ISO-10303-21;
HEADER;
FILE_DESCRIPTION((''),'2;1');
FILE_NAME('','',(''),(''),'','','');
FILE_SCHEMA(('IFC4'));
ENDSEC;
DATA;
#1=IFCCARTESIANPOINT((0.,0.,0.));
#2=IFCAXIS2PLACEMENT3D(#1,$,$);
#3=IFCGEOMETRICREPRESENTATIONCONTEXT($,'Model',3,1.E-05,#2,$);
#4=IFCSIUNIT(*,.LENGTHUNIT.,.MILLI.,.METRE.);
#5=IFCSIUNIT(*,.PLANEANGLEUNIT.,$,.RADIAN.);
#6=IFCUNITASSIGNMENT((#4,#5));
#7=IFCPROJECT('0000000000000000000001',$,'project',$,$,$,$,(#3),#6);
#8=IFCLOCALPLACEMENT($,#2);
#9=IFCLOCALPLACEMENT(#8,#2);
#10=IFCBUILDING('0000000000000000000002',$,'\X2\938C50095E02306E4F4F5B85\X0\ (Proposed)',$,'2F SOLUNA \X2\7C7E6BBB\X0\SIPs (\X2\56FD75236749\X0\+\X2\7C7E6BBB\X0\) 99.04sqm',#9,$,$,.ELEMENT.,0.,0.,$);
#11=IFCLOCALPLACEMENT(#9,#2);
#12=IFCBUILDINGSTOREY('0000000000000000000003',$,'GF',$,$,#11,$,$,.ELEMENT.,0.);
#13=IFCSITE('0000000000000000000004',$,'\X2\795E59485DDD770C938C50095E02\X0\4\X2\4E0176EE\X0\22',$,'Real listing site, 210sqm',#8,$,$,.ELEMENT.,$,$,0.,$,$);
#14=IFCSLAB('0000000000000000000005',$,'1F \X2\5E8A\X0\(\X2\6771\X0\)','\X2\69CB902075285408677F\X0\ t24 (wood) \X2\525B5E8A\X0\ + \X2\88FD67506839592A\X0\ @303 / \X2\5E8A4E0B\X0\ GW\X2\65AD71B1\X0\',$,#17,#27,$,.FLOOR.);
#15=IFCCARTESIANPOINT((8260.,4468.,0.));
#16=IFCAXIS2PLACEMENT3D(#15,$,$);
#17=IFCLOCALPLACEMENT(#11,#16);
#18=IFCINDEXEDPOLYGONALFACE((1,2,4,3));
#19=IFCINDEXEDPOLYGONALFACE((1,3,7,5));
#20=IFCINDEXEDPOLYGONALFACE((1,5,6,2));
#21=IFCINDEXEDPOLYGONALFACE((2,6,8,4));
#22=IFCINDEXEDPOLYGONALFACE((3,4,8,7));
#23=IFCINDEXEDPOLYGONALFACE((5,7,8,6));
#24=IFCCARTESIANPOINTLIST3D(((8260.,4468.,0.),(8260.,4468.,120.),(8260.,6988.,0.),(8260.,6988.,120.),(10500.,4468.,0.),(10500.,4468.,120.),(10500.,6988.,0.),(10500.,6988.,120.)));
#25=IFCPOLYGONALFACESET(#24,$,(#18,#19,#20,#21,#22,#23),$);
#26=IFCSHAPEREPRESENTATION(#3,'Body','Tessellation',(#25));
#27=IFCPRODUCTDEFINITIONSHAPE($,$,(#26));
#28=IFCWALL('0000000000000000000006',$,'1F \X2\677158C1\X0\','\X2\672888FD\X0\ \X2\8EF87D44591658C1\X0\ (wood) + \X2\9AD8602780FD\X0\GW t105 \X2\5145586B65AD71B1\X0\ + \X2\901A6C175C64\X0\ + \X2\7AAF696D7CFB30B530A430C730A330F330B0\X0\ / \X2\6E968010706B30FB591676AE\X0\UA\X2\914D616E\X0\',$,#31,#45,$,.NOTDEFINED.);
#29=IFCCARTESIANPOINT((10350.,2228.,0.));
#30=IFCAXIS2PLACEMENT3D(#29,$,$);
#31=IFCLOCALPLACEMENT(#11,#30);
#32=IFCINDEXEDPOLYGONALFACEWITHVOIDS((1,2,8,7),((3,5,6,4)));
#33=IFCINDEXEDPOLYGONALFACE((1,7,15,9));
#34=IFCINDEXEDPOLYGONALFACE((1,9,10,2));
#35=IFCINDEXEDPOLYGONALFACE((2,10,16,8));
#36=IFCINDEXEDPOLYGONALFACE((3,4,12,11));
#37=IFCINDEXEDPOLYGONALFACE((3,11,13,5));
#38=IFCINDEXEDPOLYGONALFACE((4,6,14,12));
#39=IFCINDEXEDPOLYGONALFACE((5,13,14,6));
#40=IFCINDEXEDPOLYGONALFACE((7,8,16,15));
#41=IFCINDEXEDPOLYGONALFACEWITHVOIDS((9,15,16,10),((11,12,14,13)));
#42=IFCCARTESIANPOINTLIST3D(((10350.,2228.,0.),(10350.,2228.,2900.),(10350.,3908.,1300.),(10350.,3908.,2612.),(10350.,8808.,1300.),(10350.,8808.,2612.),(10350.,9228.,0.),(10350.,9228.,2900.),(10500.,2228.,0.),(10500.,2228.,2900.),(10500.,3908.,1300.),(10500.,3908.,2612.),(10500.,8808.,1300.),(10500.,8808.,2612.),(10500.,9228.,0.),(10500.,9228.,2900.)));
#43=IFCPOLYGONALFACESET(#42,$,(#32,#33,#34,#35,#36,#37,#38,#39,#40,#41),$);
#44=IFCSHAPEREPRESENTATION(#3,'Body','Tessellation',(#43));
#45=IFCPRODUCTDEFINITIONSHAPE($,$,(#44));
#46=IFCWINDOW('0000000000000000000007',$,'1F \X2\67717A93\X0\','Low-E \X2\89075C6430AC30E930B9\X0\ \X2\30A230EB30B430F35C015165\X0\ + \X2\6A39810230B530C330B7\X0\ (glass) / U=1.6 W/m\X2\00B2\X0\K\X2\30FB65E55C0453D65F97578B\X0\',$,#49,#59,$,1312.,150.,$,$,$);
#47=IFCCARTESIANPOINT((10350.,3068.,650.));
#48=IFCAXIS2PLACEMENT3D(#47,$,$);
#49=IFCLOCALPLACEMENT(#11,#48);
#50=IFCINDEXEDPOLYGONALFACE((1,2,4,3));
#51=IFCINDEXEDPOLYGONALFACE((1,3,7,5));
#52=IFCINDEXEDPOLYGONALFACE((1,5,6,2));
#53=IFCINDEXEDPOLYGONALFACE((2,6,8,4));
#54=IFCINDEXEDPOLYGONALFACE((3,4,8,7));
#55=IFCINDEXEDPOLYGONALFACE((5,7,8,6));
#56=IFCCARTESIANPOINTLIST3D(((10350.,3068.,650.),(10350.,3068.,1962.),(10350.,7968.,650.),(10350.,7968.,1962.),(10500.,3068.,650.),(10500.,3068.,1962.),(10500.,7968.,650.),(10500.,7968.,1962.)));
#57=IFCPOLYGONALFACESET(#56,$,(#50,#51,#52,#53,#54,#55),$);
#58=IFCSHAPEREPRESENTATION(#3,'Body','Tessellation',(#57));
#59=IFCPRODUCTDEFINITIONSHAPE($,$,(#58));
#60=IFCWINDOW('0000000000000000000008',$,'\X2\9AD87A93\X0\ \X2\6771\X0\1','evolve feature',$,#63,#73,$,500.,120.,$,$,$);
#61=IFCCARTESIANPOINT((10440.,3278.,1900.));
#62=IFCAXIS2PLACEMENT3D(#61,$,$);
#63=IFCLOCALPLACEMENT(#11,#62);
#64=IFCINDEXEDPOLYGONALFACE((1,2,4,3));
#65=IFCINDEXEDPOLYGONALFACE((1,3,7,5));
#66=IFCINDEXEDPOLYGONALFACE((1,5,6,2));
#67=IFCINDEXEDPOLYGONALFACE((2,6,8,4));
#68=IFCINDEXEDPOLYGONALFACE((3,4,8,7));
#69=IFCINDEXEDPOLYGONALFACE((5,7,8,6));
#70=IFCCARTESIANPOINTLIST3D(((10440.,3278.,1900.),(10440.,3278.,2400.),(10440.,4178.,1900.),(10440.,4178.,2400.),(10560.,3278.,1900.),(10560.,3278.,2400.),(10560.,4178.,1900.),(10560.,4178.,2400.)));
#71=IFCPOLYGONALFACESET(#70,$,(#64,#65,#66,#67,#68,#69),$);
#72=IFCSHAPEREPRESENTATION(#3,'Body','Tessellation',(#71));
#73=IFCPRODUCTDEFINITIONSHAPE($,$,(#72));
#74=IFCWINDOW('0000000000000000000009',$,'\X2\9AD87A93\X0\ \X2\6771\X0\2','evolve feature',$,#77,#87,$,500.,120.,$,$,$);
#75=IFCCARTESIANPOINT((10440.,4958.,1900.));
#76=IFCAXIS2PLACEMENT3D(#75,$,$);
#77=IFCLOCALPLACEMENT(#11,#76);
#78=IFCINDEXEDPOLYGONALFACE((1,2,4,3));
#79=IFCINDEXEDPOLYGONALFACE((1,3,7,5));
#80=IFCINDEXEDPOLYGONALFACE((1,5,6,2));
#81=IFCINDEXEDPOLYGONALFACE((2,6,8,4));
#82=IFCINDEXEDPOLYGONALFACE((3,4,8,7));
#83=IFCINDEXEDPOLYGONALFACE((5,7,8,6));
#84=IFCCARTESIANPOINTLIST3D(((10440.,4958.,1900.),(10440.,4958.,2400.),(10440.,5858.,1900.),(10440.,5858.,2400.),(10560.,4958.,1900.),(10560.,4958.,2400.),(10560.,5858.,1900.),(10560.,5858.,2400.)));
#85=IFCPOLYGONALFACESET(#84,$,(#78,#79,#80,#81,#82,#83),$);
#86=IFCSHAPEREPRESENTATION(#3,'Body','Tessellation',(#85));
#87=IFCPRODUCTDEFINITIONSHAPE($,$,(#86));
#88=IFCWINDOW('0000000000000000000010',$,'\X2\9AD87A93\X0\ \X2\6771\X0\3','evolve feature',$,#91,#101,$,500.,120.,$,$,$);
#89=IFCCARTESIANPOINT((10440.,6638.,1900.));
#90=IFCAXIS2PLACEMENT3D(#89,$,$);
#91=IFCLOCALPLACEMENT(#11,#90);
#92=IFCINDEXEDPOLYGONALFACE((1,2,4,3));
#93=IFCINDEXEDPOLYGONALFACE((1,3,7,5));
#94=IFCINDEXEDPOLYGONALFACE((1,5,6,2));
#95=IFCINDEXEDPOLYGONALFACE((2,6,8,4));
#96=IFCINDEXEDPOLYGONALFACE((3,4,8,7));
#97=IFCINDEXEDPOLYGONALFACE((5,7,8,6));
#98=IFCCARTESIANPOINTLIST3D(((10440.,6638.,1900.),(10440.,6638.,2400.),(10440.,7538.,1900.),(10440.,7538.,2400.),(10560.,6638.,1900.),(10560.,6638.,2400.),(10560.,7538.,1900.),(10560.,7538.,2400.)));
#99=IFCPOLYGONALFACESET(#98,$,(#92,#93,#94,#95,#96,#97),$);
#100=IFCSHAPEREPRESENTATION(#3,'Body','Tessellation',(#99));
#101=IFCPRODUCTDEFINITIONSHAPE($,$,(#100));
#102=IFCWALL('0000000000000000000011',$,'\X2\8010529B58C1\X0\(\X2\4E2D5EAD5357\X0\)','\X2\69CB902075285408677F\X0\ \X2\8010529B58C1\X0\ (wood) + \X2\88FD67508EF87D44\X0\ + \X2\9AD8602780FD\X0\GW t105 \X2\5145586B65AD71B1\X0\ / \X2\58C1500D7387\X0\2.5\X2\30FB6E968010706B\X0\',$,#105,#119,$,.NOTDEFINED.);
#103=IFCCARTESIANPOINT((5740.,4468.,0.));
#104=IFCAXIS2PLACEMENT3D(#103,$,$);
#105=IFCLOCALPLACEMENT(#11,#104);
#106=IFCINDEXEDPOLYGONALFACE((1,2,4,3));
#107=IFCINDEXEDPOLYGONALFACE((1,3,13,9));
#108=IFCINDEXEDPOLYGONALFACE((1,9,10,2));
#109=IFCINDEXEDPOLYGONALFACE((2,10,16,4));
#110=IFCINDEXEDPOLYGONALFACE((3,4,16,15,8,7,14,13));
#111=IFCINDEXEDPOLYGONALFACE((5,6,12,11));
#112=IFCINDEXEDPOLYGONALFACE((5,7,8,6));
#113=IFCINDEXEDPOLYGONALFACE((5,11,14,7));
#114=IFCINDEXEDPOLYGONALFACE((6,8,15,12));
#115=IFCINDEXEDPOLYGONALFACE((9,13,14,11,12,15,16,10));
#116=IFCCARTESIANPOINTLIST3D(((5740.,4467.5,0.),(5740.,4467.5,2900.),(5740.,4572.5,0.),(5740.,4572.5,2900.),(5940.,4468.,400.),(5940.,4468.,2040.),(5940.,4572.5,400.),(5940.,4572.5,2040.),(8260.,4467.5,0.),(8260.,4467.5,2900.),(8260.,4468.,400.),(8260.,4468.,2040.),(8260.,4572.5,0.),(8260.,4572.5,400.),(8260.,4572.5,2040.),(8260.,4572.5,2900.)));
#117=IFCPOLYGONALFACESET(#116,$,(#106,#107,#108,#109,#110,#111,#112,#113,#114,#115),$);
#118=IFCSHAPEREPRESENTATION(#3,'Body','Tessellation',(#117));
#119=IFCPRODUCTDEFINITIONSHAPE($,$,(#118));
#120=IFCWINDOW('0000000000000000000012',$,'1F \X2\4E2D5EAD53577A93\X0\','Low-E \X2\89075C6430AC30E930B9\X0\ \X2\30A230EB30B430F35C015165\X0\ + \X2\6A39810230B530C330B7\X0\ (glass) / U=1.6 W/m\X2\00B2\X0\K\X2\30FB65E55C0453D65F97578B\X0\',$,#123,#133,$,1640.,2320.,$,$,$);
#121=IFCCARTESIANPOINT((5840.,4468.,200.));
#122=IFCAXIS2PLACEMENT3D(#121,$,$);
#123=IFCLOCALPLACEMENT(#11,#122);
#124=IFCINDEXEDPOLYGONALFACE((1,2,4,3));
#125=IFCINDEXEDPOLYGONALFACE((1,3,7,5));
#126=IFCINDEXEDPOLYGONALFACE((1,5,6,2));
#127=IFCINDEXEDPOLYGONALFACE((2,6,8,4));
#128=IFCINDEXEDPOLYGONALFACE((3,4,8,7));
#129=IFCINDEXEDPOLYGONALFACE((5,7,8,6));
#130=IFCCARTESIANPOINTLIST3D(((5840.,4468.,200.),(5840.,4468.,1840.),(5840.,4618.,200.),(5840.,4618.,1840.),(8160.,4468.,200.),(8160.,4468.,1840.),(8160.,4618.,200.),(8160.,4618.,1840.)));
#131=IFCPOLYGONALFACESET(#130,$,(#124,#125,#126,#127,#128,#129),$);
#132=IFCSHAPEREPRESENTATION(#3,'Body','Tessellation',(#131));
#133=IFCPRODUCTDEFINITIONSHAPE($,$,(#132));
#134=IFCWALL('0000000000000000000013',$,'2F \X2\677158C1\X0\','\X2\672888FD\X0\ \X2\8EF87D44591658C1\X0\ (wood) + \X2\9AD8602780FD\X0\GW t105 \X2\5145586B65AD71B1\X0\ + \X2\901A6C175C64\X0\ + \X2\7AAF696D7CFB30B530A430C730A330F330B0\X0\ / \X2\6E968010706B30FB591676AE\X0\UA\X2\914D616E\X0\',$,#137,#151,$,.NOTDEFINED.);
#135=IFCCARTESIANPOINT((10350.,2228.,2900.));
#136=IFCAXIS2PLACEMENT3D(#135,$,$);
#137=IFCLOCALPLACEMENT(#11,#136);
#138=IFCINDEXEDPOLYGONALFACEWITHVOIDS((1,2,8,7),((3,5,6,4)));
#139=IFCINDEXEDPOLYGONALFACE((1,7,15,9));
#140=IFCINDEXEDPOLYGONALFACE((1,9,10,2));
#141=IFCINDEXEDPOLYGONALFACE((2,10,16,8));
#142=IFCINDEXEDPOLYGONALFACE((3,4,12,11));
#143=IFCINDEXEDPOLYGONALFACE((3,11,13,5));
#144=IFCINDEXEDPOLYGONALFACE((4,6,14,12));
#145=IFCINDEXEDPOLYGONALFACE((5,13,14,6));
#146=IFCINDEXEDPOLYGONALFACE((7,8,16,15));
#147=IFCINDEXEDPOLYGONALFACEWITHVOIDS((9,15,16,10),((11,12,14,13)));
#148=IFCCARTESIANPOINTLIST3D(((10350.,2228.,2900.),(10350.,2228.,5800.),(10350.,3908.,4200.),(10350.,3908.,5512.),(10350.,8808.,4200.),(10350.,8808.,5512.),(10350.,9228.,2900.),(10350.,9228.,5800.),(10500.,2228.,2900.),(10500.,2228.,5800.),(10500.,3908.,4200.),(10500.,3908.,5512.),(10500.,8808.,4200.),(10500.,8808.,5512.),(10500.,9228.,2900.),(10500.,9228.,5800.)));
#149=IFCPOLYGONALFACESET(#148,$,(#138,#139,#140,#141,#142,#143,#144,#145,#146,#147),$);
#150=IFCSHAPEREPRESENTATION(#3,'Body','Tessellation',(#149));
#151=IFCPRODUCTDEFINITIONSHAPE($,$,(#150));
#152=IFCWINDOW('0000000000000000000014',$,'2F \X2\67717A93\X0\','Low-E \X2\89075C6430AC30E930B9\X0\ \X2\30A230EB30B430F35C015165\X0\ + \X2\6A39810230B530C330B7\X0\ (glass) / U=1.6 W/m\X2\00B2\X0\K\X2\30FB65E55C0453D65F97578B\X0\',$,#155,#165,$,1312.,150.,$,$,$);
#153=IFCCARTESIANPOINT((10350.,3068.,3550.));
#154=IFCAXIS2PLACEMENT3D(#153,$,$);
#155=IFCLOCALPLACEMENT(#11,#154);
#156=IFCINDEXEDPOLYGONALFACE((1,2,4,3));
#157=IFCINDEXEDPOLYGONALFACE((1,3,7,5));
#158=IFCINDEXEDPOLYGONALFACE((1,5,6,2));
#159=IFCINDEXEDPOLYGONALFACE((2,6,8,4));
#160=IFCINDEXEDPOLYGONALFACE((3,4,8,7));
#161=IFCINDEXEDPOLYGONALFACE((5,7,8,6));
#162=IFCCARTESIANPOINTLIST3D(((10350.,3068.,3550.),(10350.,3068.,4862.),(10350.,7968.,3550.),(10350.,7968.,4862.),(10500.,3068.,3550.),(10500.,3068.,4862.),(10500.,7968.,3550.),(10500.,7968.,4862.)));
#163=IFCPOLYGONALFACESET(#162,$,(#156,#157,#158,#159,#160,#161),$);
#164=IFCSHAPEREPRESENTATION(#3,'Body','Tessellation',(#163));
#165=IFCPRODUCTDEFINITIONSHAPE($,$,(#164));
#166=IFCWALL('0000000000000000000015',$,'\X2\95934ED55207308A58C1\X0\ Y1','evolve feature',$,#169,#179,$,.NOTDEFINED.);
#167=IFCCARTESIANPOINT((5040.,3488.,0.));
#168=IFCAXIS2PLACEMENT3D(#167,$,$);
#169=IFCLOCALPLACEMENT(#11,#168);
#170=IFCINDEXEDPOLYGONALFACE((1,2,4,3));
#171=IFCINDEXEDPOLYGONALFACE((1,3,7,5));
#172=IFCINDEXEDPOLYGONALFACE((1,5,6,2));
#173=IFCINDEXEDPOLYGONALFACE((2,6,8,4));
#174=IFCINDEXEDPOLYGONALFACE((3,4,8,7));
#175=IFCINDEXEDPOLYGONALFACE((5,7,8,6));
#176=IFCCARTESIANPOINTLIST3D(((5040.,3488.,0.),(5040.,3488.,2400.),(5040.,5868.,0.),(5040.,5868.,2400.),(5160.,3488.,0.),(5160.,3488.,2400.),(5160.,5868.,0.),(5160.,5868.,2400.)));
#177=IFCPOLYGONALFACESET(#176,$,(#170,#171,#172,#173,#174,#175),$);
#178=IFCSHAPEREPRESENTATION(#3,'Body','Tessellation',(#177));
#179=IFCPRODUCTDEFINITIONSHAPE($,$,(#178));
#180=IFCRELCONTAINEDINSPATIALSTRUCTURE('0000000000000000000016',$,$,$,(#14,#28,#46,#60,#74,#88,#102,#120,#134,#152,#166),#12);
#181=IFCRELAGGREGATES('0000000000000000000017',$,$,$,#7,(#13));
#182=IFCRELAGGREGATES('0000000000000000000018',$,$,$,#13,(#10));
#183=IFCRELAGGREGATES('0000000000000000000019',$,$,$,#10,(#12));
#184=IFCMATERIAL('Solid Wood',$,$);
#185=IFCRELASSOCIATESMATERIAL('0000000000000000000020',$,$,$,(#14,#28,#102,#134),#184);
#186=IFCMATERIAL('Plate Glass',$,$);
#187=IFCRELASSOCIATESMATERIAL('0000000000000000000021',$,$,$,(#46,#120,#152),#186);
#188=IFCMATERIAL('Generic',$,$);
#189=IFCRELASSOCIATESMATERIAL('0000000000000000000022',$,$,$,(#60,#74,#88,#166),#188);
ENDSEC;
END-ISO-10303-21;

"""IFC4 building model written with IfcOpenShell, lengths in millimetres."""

from ifc_helpers import new_model, si_unit, frame, frame_2d, origin, place, context, project, spatial, rectangle, extrude, material, element, fill, save


model = new_model("IFC4")

# Units and contexts
model_context = context("Model", 3, precision=1e-05, world=origin())
ifc_project = project(units=[si_unit("LENGTHUNIT", "METRE", prefix="MILLI"), si_unit("PLANEANGLEUNIT", "RADIAN")], contexts=[model_context])

# Site, building, storey
site_placement = place(None, origin())
site = spatial("IfcSite", under=ifc_project, at=site_placement, Name="神奈川県鎌倉市4丁目22", ObjectType="Real listing site, 210sqm", CompositionType="ELEMENT", RefElevation=0.0)
building_placement = place(site_placement, origin())
building = spatial("IfcBuilding", under=site, at=building_placement, Name="鎌倉市の住宅 (Proposed)", ObjectType="2F SOLUNA 籾殻SIPs (国産杉+籾殻) 99.04sqm", CompositionType="ELEMENT", ElevationOfRefHeight=0.0, ElevationOfTerrain=0.0)
storey_placement = place(building_placement, origin())
storey = spatial("IfcBuildingStorey", under=building, at=storey_placement, Name="GF", CompositionType="ELEMENT", Elevation=0.0)

# Slab
ifc_material_1 = material(Name="Solid Wood")
slab_placement = place(storey_placement, frame((8260.0, 4468.0, 0.0)))
element("IfcSlab", 1, at=slab_placement, inside=storey, material=ifc_material_1, Name="1F 床(東)", Description="構造用合板 t24 (wood) 剛床 + 製材根太 @303 / 床下 GW断熱", PredefinedType="FLOOR", context=model_context, shape_type="SweptSolid", body=[
    extrude(rectangle(XDim=2240.0, YDim=2520.0, at=frame_2d((1120.0, 1260.0))), frame((8260.0, 4468.0, 0.0)), (0.0, 0.0, 1.0), 120.0),
])

# Wall, openings, windows
wall_1_placement = place(storey_placement, frame((10350.0, 2228.0, 0.0)))
wall_1 = element("IfcWall", 2, at=wall_1_placement, inside=storey, material=ifc_material_1, Name="1F 東壁", Description="木製 軸組外壁 (wood) + 高性能GW t105 充填断熱 + 通気層 + 窯業系サイディング / 準耐火・外皮UA配慮", PredefinedType="NOTDEFINED", context=model_context, shape_type="SweptSolid", body=[
    extrude(rectangle(XDim=150.0, YDim=7000.0, at=frame_2d((75.0, 3500.0))), frame((10350.0, 2228.0, 0.0)), (0.0, 0.0, 1.0), 2900.0),
])
opening_1_placement = place(storey_placement, frame((10350.0, 3068.0, 650.0)))
opening_1 = element("IfcOpeningElement", 3, at=opening_1_placement, cuts=wall_1, PredefinedType="NOTDEFINED", context=model_context, shape_type="SweptSolid", body=[
    extrude(rectangle(XDim=150.0, YDim=4900.0, at=frame_2d((75.0, 2450.0))), frame((10350.0, 3068.0, 650.0)), (0.0, 0.0, 1.0), 1312.0),
])
opening_2_placement = place(storey_placement, frame((10440.0, 3278.0, 1900.0)))
opening_2 = element("IfcOpeningElement", 4, at=opening_2_placement, cuts=wall_1, PredefinedType="NOTDEFINED", context=model_context, shape_type="SweptSolid", body=[
    extrude(rectangle(XDim=120.0, YDim=900.0, at=frame_2d((60.0, 450.0))), frame((10440.0, 3278.0, 1900.0)), (0.0, 0.0, 1.0), 500.0),
])
opening_3_placement = place(storey_placement, frame((10440.0, 4958.0, 1900.0)))
opening_3 = element("IfcOpeningElement", 5, at=opening_3_placement, cuts=wall_1, PredefinedType="NOTDEFINED", context=model_context, shape_type="SweptSolid", body=[
    extrude(rectangle(XDim=120.0, YDim=900.0, at=frame_2d((60.0, 450.0))), frame((10440.0, 4958.0, 1900.0)), (0.0, 0.0, 1.0), 500.0),
])
opening_4_placement = place(storey_placement, frame((10440.0, 6638.0, 1900.0)))
opening_4 = element("IfcOpeningElement", 6, at=opening_4_placement, cuts=wall_1, PredefinedType="NOTDEFINED", context=model_context, shape_type="SweptSolid", body=[
    extrude(rectangle(XDim=120.0, YDim=900.0, at=frame_2d((60.0, 450.0))), frame((10440.0, 6638.0, 1900.0)), (0.0, 0.0, 1.0), 500.0),
])
ifc_material_2 = material(Name="Plate Glass")
window_1_placement = place(storey_placement, frame((10350.0, 3068.0, 650.0)))
window_1 = element("IfcWindow", 7, at=window_1_placement, inside=storey, material=ifc_material_2, Name="1F 東窓", Description="Low-E 複層ガラス アルゴン封入 + 樹脂サッシ (glass) / U=1.6 W/m²K・日射取得型", OverallHeight=1312.0, OverallWidth=150.0, context=model_context, shape_type="SweptSolid", body=[
    extrude(rectangle(XDim=150.0, YDim=4900.0, at=frame_2d((75.0, 2450.0))), frame((10350.0, 3068.0, 650.0)), (0.0, 0.0, 1.0), 1312.0),
])
fill(opening_1, window_1)
ifc_material_3 = material(Name="Generic")
window_2_placement = place(storey_placement, frame((10440.0, 3278.0, 1900.0)))
window_2 = element("IfcWindow", 8, at=window_2_placement, inside=storey, material=ifc_material_3, Name="高窓 東1", Description="evolve feature", OverallHeight=500.0, OverallWidth=120.0, context=model_context, shape_type="SweptSolid", body=[
    extrude(rectangle(XDim=120.0, YDim=900.0, at=frame_2d((60.0, 450.0))), frame((10440.0, 3278.0, 1900.0)), (0.0, 0.0, 1.0), 500.0),
])
fill(opening_2, window_2)
window_3_placement = place(storey_placement, frame((10440.0, 4958.0, 1900.0)))
window_3 = element("IfcWindow", 9, at=window_3_placement, inside=storey, material=ifc_material_3, Name="高窓 東2", Description="evolve feature", OverallHeight=500.0, OverallWidth=120.0, context=model_context, shape_type="SweptSolid", body=[
    extrude(rectangle(XDim=120.0, YDim=900.0, at=frame_2d((60.0, 450.0))), frame((10440.0, 4958.0, 1900.0)), (0.0, 0.0, 1.0), 500.0),
])
fill(opening_3, window_3)
window_4_placement = place(storey_placement, frame((10440.0, 6638.0, 1900.0)))
window_4 = element("IfcWindow", 10, at=window_4_placement, inside=storey, material=ifc_material_3, Name="高窓 東3", Description="evolve feature", OverallHeight=500.0, OverallWidth=120.0, context=model_context, shape_type="SweptSolid", body=[
    extrude(rectangle(XDim=120.0, YDim=900.0, at=frame_2d((60.0, 450.0))), frame((10440.0, 6638.0, 1900.0)), (0.0, 0.0, 1.0), 500.0),
])
fill(opening_4, window_4)

# Wall, opening, window
wall_2_placement = place(storey_placement, frame((5740.0, 4468.0, 0.0)))
wall_2 = element("IfcWall", 11, at=wall_2_placement, inside=storey, material=ifc_material_1, Name="耐力壁(中庭南)", Description="構造用合板 耐力壁 (wood) + 製材軸組 + 高性能GW t105 充填断熱 / 壁倍率2.5・準耐火", PredefinedType="NOTDEFINED", context=model_context, shape_type="SweptSolid", body=[
    extrude(rectangle(XDim=2520.0, YDim=105.0, at=frame_2d((1260.0, 52.0))), frame((5740.0, 4468.0, 0.0)), (0.0, 0.0, 1.0), 2900.0),
])
opening_5_placement = place(storey_placement, frame((5840.0, 4468.0, 200.0)))
opening_5 = element("IfcOpeningElement", 12, at=opening_5_placement, cuts=wall_2, PredefinedType="NOTDEFINED", context=model_context, shape_type="SweptSolid", body=[
    extrude(rectangle(XDim=2320.0, YDim=150.0, at=frame_2d((1160.0, 75.0))), frame((5840.0, 4468.0, 200.0)), (0.0, 0.0, 1.0), 1640.0),
])
window_5_placement = place(storey_placement, frame((5840.0, 4468.0, 200.0)))
window_5 = element("IfcWindow", 13, at=window_5_placement, inside=storey, material=ifc_material_2, Name="1F 中庭南窓", Description="Low-E 複層ガラス アルゴン封入 + 樹脂サッシ (glass) / U=1.6 W/m²K・日射取得型", OverallHeight=1640.0, OverallWidth=2320.0, context=model_context, shape_type="SweptSolid", body=[
    extrude(rectangle(XDim=2320.0, YDim=150.0, at=frame_2d((1160.0, 75.0))), frame((5840.0, 4468.0, 200.0)), (0.0, 0.0, 1.0), 1640.0),
])
fill(opening_5, window_5)

# Wall, opening, window
wall_3_placement = place(storey_placement, frame((10350.0, 2228.0, 2900.0)))
wall_3 = element("IfcWall", 14, at=wall_3_placement, inside=storey, material=ifc_material_1, Name="2F 東壁", Description="木製 軸組外壁 (wood) + 高性能GW t105 充填断熱 + 通気層 + 窯業系サイディング / 準耐火・外皮UA配慮", PredefinedType="NOTDEFINED", context=model_context, shape_type="SweptSolid", body=[
    extrude(rectangle(XDim=150.0, YDim=7000.0, at=frame_2d((75.0, 3500.0))), frame((10350.0, 2228.0, 2900.0)), (0.0, 0.0, 1.0), 2900.0),
])
opening_6_placement = place(storey_placement, frame((10350.0, 3068.0, 3550.0)))
opening_6 = element("IfcOpeningElement", 15, at=opening_6_placement, cuts=wall_3, PredefinedType="NOTDEFINED", context=model_context, shape_type="SweptSolid", body=[
    extrude(rectangle(XDim=150.0, YDim=4900.0, at=frame_2d((75.0, 2450.0))), frame((10350.0, 3068.0, 3550.0)), (0.0, 0.0, 1.0), 1312.0),
])
window_6_placement = place(storey_placement, frame((10350.0, 3068.0, 3550.0)))
window_6 = element("IfcWindow", 16, at=window_6_placement, inside=storey, material=ifc_material_2, Name="2F 東窓", Description="Low-E 複層ガラス アルゴン封入 + 樹脂サッシ (glass) / U=1.6 W/m²K・日射取得型", OverallHeight=1312.0, OverallWidth=150.0, context=model_context, shape_type="SweptSolid", body=[
    extrude(rectangle(XDim=150.0, YDim=4900.0, at=frame_2d((75.0, 2450.0))), frame((10350.0, 3068.0, 3550.0)), (0.0, 0.0, 1.0), 1312.0),
])
fill(opening_6, window_6)

# Wall
wall_4_placement = place(storey_placement, frame((5040.0, 3488.0, 0.0)))
element("IfcWall", 17, at=wall_4_placement, inside=storey, material=ifc_material_3, Name="間仕切り壁 Y1", Description="evolve feature", PredefinedType="NOTDEFINED", context=model_context, shape_type="SweptSolid", body=[
    extrude(rectangle(XDim=120.0, YDim=2380.0, at=frame_2d((60.0, 1190.0))), frame((5040.0, 3488.0, 0.0)), (0.0, 0.0, 1.0), 2400.0),
])

save(model, "model.ifc")
